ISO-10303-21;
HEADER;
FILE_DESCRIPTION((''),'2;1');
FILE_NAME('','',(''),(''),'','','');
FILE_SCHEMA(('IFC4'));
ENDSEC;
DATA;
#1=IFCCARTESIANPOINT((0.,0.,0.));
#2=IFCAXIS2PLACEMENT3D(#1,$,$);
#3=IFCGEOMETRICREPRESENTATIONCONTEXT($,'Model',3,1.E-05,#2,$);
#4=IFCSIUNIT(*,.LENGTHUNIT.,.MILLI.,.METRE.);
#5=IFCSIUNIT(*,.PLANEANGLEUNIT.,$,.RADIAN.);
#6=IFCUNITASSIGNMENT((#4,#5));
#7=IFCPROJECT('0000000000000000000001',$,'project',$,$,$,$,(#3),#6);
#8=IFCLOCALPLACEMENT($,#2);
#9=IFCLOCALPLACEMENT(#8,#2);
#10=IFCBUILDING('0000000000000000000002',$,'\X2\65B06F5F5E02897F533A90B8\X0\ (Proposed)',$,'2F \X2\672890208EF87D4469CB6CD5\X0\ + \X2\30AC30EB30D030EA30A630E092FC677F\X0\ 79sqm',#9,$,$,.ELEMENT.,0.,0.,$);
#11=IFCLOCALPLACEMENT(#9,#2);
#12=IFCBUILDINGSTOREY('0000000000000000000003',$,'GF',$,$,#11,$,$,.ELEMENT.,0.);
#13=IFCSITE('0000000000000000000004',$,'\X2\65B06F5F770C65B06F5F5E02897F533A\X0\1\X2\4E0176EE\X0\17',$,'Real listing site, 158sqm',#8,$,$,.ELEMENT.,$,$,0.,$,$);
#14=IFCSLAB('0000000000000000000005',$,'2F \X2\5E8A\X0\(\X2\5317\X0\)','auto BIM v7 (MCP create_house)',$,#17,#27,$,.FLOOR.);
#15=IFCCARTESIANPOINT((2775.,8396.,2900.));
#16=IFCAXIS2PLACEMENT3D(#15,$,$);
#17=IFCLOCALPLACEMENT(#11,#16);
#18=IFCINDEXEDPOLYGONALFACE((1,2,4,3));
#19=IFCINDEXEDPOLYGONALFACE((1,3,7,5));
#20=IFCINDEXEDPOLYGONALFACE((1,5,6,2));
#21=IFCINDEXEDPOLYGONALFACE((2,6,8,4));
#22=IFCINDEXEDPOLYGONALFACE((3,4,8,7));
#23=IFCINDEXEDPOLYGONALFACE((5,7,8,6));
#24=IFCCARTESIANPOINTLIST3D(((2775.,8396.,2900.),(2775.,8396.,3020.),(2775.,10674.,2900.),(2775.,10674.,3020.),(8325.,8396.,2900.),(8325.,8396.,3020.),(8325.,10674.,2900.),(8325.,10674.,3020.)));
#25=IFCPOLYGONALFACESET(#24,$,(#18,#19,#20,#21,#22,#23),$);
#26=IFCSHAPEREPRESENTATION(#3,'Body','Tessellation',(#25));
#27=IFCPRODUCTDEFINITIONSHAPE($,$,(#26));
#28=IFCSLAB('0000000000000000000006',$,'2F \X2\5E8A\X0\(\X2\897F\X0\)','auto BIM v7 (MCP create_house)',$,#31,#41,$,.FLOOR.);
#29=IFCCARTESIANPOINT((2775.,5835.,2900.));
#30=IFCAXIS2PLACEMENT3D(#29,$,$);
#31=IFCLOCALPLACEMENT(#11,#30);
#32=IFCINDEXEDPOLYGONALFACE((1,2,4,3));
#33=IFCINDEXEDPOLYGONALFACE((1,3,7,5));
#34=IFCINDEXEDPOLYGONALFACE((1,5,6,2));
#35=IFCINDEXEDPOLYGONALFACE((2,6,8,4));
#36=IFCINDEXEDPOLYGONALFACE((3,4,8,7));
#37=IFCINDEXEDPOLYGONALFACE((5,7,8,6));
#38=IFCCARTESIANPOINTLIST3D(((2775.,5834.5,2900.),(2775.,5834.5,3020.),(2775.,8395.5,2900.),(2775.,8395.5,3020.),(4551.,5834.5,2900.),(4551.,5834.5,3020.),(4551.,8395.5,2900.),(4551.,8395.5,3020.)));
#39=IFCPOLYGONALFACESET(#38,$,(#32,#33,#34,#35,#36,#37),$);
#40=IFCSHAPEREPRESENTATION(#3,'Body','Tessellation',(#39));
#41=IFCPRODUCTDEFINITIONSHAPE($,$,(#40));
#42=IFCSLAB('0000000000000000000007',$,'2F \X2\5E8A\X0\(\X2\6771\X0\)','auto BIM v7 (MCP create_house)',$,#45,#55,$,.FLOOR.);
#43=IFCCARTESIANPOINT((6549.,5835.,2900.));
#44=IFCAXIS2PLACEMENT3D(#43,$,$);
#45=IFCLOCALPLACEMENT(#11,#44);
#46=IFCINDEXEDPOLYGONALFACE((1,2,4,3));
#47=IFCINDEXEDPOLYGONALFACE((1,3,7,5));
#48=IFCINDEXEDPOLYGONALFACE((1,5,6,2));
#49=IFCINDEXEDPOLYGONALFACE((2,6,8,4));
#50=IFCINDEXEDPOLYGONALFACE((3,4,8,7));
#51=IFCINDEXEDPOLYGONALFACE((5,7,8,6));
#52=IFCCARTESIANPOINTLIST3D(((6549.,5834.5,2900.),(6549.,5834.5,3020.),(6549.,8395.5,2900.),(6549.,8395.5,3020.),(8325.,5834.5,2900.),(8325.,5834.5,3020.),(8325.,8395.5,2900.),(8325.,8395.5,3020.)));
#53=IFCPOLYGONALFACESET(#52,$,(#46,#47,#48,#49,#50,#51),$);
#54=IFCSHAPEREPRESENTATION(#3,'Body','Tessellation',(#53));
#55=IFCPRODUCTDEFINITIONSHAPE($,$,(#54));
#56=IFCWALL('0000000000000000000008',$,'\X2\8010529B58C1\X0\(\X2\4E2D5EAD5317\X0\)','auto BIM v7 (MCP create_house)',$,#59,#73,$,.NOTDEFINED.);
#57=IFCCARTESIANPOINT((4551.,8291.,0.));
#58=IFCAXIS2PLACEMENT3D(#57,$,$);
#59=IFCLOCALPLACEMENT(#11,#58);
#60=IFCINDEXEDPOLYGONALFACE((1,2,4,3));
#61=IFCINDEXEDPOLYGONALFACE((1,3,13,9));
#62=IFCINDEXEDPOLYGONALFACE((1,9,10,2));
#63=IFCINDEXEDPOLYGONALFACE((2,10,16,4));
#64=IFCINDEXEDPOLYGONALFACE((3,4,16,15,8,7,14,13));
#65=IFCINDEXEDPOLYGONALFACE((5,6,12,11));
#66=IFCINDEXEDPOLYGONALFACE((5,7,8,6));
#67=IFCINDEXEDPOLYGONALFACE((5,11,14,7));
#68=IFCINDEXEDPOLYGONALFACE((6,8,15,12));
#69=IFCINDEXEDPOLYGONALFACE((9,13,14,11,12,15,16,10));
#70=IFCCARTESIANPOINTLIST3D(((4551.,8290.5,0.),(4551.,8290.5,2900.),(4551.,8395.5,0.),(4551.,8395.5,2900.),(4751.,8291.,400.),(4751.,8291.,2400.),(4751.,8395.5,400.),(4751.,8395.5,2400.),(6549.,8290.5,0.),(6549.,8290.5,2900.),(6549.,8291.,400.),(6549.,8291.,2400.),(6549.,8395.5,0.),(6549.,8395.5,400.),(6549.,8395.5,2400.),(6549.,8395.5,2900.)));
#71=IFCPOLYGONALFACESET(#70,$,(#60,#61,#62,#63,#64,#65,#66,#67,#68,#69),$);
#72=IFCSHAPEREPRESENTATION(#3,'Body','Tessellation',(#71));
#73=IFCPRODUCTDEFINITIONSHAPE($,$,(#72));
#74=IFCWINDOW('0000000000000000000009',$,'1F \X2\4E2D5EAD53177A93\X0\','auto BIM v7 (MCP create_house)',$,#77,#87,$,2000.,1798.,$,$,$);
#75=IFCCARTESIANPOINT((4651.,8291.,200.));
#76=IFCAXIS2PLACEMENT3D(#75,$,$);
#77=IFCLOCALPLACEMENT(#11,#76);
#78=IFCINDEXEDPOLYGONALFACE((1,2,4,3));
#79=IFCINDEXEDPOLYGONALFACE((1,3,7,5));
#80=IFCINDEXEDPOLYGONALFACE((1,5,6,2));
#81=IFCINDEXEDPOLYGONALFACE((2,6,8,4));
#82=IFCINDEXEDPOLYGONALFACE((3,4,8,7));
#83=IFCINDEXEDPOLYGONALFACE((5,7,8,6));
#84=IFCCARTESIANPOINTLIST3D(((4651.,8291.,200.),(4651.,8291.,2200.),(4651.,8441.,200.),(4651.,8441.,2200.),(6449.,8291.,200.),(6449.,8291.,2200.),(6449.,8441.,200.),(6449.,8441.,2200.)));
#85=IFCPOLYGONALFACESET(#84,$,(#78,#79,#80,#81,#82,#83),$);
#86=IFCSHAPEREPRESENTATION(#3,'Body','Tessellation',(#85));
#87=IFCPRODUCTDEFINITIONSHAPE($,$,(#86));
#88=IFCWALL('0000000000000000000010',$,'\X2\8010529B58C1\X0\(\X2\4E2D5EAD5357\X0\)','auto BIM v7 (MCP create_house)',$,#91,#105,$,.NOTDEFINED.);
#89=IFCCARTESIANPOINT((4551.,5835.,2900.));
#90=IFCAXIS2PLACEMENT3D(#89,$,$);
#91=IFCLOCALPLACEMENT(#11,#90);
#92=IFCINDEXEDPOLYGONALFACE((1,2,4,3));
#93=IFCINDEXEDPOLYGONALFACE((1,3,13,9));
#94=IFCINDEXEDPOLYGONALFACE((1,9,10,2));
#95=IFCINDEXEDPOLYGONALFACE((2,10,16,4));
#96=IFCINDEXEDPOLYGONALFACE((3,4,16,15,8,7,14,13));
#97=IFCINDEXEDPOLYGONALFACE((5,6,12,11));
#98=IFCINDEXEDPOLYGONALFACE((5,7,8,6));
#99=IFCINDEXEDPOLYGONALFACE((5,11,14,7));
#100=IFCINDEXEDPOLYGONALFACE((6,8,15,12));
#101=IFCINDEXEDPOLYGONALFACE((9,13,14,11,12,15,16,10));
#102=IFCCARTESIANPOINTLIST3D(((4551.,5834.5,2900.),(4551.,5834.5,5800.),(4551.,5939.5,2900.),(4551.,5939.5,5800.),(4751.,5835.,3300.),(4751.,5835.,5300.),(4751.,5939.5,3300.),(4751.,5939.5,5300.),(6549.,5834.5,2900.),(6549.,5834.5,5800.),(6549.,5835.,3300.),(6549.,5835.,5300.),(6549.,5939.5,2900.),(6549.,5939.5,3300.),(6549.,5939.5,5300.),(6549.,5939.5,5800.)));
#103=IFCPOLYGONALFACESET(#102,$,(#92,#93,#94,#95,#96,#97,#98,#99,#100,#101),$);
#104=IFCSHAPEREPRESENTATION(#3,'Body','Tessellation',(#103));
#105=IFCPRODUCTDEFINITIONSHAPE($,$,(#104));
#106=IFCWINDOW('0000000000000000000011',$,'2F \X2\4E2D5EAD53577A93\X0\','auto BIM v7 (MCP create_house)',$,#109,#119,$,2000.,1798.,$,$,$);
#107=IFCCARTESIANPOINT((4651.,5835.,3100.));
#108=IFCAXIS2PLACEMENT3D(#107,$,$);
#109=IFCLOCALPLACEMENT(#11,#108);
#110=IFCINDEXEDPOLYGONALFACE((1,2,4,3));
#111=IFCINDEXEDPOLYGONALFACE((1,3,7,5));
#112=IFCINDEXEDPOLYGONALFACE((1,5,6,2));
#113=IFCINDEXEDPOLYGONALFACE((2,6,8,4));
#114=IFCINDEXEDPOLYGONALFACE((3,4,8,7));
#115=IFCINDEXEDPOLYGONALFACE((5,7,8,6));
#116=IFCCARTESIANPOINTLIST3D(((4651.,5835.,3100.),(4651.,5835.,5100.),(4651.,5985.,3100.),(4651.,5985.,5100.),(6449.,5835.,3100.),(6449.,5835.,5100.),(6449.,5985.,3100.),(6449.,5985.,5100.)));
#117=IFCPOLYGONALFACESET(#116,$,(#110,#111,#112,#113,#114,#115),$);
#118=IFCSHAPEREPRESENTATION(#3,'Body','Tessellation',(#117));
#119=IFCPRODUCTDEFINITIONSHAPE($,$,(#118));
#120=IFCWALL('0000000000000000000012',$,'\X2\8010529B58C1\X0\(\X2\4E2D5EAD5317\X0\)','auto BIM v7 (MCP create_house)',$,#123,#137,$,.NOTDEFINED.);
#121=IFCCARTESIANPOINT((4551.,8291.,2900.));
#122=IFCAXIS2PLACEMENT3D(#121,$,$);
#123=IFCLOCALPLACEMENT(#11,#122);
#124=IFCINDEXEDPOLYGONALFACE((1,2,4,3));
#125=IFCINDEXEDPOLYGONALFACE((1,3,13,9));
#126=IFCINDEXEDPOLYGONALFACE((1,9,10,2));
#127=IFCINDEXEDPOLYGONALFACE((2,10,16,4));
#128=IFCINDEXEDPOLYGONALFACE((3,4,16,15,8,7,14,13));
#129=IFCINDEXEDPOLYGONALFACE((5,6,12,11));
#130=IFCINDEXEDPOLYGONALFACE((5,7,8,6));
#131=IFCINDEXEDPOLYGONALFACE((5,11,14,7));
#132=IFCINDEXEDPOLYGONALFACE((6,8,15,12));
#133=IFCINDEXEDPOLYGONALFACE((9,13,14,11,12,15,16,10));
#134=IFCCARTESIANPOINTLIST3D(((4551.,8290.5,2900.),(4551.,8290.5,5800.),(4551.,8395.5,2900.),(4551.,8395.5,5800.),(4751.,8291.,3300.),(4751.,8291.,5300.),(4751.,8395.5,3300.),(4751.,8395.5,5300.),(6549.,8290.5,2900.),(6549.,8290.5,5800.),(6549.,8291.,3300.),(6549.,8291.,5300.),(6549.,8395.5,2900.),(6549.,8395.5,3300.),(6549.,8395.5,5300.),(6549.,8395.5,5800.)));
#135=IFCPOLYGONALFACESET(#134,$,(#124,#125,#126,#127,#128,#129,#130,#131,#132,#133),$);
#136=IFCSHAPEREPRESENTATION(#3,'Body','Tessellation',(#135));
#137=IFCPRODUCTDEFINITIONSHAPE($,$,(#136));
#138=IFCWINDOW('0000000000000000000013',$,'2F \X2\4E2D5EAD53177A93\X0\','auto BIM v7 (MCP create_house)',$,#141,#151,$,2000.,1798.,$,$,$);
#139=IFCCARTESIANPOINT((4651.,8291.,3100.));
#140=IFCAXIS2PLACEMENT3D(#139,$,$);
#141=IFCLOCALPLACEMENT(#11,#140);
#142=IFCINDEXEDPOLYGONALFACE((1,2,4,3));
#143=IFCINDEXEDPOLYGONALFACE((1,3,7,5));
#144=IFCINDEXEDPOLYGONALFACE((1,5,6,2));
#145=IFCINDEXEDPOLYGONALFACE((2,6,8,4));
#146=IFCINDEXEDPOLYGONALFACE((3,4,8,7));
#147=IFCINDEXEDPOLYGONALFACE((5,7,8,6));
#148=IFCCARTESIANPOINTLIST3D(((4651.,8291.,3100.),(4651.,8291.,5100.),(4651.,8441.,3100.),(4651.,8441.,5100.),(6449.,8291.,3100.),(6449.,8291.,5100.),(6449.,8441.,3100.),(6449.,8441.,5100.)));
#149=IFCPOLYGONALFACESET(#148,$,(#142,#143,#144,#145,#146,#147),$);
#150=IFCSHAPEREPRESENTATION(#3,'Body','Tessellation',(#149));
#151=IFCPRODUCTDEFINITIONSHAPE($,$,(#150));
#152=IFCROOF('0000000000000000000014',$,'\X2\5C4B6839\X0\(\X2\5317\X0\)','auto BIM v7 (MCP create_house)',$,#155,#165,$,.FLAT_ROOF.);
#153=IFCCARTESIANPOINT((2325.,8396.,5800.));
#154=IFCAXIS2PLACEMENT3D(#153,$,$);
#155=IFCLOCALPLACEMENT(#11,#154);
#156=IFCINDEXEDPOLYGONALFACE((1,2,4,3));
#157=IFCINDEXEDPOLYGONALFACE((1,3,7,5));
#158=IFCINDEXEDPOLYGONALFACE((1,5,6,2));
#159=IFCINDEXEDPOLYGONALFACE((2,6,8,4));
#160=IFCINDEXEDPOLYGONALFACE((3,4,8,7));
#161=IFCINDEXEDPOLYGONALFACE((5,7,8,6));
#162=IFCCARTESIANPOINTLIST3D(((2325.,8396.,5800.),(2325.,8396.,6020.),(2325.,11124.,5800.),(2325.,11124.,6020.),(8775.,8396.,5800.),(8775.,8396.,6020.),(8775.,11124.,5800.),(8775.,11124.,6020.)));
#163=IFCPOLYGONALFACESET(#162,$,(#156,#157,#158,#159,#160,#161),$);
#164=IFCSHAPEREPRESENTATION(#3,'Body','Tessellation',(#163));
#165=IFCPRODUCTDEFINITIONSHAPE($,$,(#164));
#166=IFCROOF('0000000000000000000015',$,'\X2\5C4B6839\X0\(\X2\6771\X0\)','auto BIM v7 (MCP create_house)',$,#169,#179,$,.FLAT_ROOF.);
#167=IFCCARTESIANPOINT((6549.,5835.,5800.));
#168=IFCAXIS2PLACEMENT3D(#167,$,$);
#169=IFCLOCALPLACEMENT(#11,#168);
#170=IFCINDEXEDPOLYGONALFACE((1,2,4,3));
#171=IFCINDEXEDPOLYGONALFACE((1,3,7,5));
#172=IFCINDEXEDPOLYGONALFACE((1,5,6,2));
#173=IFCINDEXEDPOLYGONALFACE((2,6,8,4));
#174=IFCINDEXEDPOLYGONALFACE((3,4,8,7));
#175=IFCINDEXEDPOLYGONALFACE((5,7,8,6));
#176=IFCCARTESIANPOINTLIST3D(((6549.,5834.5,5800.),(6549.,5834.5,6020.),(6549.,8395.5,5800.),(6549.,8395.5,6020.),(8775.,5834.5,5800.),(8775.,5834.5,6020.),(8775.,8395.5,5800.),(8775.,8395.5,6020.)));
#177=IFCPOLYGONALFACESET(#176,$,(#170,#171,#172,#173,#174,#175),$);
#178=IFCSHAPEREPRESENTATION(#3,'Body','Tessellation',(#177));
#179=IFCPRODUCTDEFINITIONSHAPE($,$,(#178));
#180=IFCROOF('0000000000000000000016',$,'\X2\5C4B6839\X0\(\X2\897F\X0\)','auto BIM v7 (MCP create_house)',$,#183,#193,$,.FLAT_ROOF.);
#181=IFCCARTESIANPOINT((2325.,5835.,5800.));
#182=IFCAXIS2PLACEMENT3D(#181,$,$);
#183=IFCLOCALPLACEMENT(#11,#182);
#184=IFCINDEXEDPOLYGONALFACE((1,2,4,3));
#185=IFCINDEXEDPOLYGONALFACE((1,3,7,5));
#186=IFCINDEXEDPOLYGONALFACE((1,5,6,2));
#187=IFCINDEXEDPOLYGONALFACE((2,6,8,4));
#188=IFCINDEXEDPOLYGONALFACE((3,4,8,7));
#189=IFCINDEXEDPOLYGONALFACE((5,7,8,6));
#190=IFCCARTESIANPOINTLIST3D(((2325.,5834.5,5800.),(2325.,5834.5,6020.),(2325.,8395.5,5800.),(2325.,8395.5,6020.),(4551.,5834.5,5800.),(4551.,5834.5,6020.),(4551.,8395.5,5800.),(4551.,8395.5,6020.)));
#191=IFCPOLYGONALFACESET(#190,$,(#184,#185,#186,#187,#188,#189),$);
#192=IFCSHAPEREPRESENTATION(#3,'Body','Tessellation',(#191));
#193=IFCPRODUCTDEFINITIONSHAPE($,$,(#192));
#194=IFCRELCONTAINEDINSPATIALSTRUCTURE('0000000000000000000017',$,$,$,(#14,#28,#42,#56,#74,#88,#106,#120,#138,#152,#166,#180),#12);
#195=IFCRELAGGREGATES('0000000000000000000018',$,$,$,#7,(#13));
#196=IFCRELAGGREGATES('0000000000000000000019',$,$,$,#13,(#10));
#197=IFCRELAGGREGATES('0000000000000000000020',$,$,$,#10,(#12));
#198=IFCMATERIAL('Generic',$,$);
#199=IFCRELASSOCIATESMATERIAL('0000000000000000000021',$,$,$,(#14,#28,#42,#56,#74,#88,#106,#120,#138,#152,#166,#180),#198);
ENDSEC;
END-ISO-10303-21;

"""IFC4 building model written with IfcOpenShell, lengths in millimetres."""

from ifc_helpers import new_model, si_unit, frame, frame_2d, origin, place, context, project, spatial, rectangle, extrude, material, element, fill, save


model = new_model("IFC4")

# Units and contexts
model_context = context("Model", 3, precision=1e-05, world=origin())
ifc_project = project(units=[si_unit("LENGTHUNIT", "METRE", prefix="MILLI"), si_unit("PLANEANGLEUNIT", "RADIAN")], contexts=[model_context])

# Site, building, storey
site_placement = place(None, origin())
site = spatial("IfcSite", under=ifc_project, at=site_placement, Name="新潟県新潟市西区1丁目17", ObjectType="Real listing site, 158sqm", CompositionType="ELEMENT", RefElevation=0.0)
building_placement = place(site_placement, origin())
building = spatial("IfcBuilding", under=site, at=building_placement, Name="新潟市西区邸 (Proposed)", ObjectType="2F 木造軸組構法 + ガルバリウム鋼板 79sqm", CompositionType="ELEMENT", ElevationOfRefHeight=0.0, ElevationOfTerrain=0.0)
storey_placement = place(building_placement, origin())
storey = spatial("IfcBuildingStorey", under=building, at=storey_placement, Name="GF", CompositionType="ELEMENT", Elevation=0.0)

# Slabs
ifc_material = material(Name="Generic")
slab_1_placement = place(storey_placement, frame((2775.0, 8396.0, 2900.0)))
element("IfcSlab", 1, at=slab_1_placement, inside=storey, material=ifc_material, Name="2F 床(北)", Description="auto BIM v7 (MCP create_house)", PredefinedType="FLOOR", context=model_context, shape_type="SweptSolid", body=[
    extrude(rectangle(XDim=5550.0, YDim=2278.0, at=frame_2d((2775.0, 1139.0))), frame((2775.0, 8396.0, 2900.0)), (0.0, 0.0, 1.0), 120.0),
])
slab_2_placement = place(storey_placement, frame((2775.0, 5835.0, 2900.0)))
element("IfcSlab", 2, at=slab_2_placement, inside=storey, material=ifc_material, Name="2F 床(西)", Description="auto BIM v7 (MCP create_house)", PredefinedType="FLOOR", context=model_context, shape_type="SweptSolid", body=[
    extrude(rectangle(XDim=1776.0, YDim=2561.0, at=frame_2d((888.0, 1280.0))), frame((2775.0, 5835.0, 2900.0)), (0.0, 0.0, 1.0), 120.0),
])
slab_3_placement = place(storey_placement, frame((6549.0, 5835.0, 2900.0)))
element("IfcSlab", 3, at=slab_3_placement, inside=storey, material=ifc_material, Name="2F 床(東)", Description="auto BIM v7 (MCP create_house)", PredefinedType="FLOOR", context=model_context, shape_type="SweptSolid", body=[
    extrude(rectangle(XDim=1776.0, YDim=2561.0, at=frame_2d((888.0, 1280.0))), frame((6549.0, 5835.0, 2900.0)), (0.0, 0.0, 1.0), 120.0),
])

# Wall, opening, window
wall_1_placement = place(storey_placement, frame((4551.0, 8291.0, 0.0)))
wall_1 = element("IfcWall", 4, at=wall_1_placement, inside=storey, material=ifc_material, Name="耐力壁(中庭北)", Description="auto BIM v7 (MCP create_house)", PredefinedType="NOTDEFINED", context=model_context, shape_type="SweptSolid", body=[
    extrude(rectangle(XDim=1998.0, YDim=105.0, at=frame_2d((999.0, 52.0))), frame((4551.0, 8291.0, 0.0)), (0.0, 0.0, 1.0), 2900.0),
])
opening_1_placement = place(storey_placement, frame((4651.0, 8291.0, 200.0)))
opening_1 = element("IfcOpeningElement", 5, at=opening_1_placement, cuts=wall_1, PredefinedType="NOTDEFINED", context=model_context, shape_type="SweptSolid", body=[
    extrude(rectangle(XDim=1798.0, YDim=150.0, at=frame_2d((899.0, 75.0))), frame((4651.0, 8291.0, 200.0)), (0.0, 0.0, 1.0), 2000.0),
])
window_1_placement = place(storey_placement, frame((4651.0, 8291.0, 200.0)))
window_1 = element("IfcWindow", 6, at=window_1_placement, inside=storey, material=ifc_material, Name="1F 中庭北窓", Description="auto BIM v7 (MCP create_house)", OverallHeight=2000.0, OverallWidth=1798.0, context=model_context, shape_type="SweptSolid", body=[
    extrude(rectangle(XDim=1798.0, YDim=150.0, at=frame_2d((899.0, 75.0))), frame((4651.0, 8291.0, 200.0)), (0.0, 0.0, 1.0), 2000.0),
])
fill(opening_1, window_1)

# Walls, openings, windows
wall_2_placement = place(storey_placement, frame((4551.0, 5835.0, 2900.0)))
wall_2 = element("IfcWall", 7, at=wall_2_placement, inside=storey, material=ifc_material, Name="耐力壁(中庭南)", Description="auto BIM v7 (MCP create_house)", PredefinedType="NOTDEFINED", context=model_context, shape_type="SweptSolid", body=[
    extrude(rectangle(XDim=1998.0, YDim=105.0, at=frame_2d((999.0, 52.0))), frame((4551.0, 5835.0, 2900.0)), (0.0, 0.0, 1.0), 2900.0),
])
opening_2_placement = place(storey_placement, frame((4651.0, 5835.0, 3100.0)))
opening_2 = element("IfcOpeningElement", 8, at=opening_2_placement, cuts=wall_2, PredefinedType="NOTDEFINED", context=model_context, shape_type="SweptSolid", body=[
    extrude(rectangle(XDim=1798.0, YDim=150.0, at=frame_2d((899.0, 75.0))), frame((4651.0, 5835.0, 3100.0)), (0.0, 0.0, 1.0), 2000.0),
])
window_2_placement = place(storey_placement, frame((4651.0, 5835.0, 3100.0)))
window_2 = element("IfcWindow", 9, at=window_2_placement, inside=storey, material=ifc_material, Name="2F 中庭南窓", Description="auto BIM v7 (MCP create_house)", OverallHeight=2000.0, OverallWidth=1798.0, context=model_context, shape_type="SweptSolid", body=[
    extrude(rectangle(XDim=1798.0, YDim=150.0, at=frame_2d((899.0, 75.0))), frame((4651.0, 5835.0, 3100.0)), (0.0, 0.0, 1.0), 2000.0),
])
fill(opening_2, window_2)
wall_3_placement = place(storey_placement, frame((4551.0, 8291.0, 2900.0)))
wall_3 = element("IfcWall", 10, at=wall_3_placement, inside=storey, material=ifc_material, Name="耐力壁(中庭北)", Description="auto BIM v7 (MCP create_house)", PredefinedType="NOTDEFINED", context=model_context, shape_type="SweptSolid", body=[
    extrude(rectangle(XDim=1998.0, YDim=105.0, at=frame_2d((999.0, 52.0))), frame((4551.0, 8291.0, 2900.0)), (0.0, 0.0, 1.0), 2900.0),
])
opening_3_placement = place(storey_placement, frame((4651.0, 8291.0, 3100.0)))
opening_3 = element("IfcOpeningElement", 11, at=opening_3_placement, cuts=wall_3, PredefinedType="NOTDEFINED", context=model_context, shape_type="SweptSolid", body=[
    extrude(rectangle(XDim=1798.0, YDim=150.0, at=frame_2d((899.0, 75.0))), frame((4651.0, 8291.0, 3100.0)), (0.0, 0.0, 1.0), 2000.0),
])
window_3_placement = place(storey_placement, frame((4651.0, 8291.0, 3100.0)))
window_3 = element("IfcWindow", 12, at=window_3_placement, inside=storey, material=ifc_material, Name="2F 中庭北窓", Description="auto BIM v7 (MCP create_house)", OverallHeight=2000.0, OverallWidth=1798.0, context=model_context, shape_type="SweptSolid", body=[
    extrude(rectangle(XDim=1798.0, YDim=150.0, at=frame_2d((899.0, 75.0))), frame((4651.0, 8291.0, 3100.0)), (0.0, 0.0, 1.0), 2000.0),
])
fill(opening_3, window_3)

# Roofs
roof_1_placement = place(storey_placement, frame((2325.0, 8396.0, 5800.0)))
element("IfcRoof", 13, at=roof_1_placement, inside=storey, material=ifc_material, Name="屋根(北)", Description="auto BIM v7 (MCP create_house)", PredefinedType="FLAT_ROOF", context=model_context, shape_type="SweptSolid", body=[
    extrude(rectangle(XDim=6450.0, YDim=2728.0, at=frame_2d((3225.0, 1364.0))), frame((2325.0, 8396.0, 5800.0)), (0.0, 0.0, 1.0), 220.0),
])
roof_2_placement = place(storey_placement, frame((6549.0, 5835.0, 5800.0)))
element("IfcRoof", 14, at=roof_2_placement, inside=storey, material=ifc_material, Name="屋根(東)", Description="auto BIM v7 (MCP create_house)", PredefinedType="FLAT_ROOF", context=model_context, shape_type="SweptSolid", body=[
    extrude(rectangle(XDim=2226.0, YDim=2561.0, at=frame_2d((1113.0, 1280.0))), frame((6549.0, 5835.0, 5800.0)), (0.0, 0.0, 1.0), 220.0),
])
roof_3_placement = place(storey_placement, frame((2325.0, 5835.0, 5800.0)))
element("IfcRoof", 15, at=roof_3_placement, inside=storey, material=ifc_material, Name="屋根(西)", Description="auto BIM v7 (MCP create_house)", PredefinedType="FLAT_ROOF", context=model_context, shape_type="SweptSolid", body=[
    extrude(rectangle(XDim=2226.0, YDim=2561.0, at=frame_2d((1113.0, 1280.0))), frame((2325.0, 5835.0, 5800.0)), (0.0, 0.0, 1.0), 220.0),
])

save(model, "model.ifc")
